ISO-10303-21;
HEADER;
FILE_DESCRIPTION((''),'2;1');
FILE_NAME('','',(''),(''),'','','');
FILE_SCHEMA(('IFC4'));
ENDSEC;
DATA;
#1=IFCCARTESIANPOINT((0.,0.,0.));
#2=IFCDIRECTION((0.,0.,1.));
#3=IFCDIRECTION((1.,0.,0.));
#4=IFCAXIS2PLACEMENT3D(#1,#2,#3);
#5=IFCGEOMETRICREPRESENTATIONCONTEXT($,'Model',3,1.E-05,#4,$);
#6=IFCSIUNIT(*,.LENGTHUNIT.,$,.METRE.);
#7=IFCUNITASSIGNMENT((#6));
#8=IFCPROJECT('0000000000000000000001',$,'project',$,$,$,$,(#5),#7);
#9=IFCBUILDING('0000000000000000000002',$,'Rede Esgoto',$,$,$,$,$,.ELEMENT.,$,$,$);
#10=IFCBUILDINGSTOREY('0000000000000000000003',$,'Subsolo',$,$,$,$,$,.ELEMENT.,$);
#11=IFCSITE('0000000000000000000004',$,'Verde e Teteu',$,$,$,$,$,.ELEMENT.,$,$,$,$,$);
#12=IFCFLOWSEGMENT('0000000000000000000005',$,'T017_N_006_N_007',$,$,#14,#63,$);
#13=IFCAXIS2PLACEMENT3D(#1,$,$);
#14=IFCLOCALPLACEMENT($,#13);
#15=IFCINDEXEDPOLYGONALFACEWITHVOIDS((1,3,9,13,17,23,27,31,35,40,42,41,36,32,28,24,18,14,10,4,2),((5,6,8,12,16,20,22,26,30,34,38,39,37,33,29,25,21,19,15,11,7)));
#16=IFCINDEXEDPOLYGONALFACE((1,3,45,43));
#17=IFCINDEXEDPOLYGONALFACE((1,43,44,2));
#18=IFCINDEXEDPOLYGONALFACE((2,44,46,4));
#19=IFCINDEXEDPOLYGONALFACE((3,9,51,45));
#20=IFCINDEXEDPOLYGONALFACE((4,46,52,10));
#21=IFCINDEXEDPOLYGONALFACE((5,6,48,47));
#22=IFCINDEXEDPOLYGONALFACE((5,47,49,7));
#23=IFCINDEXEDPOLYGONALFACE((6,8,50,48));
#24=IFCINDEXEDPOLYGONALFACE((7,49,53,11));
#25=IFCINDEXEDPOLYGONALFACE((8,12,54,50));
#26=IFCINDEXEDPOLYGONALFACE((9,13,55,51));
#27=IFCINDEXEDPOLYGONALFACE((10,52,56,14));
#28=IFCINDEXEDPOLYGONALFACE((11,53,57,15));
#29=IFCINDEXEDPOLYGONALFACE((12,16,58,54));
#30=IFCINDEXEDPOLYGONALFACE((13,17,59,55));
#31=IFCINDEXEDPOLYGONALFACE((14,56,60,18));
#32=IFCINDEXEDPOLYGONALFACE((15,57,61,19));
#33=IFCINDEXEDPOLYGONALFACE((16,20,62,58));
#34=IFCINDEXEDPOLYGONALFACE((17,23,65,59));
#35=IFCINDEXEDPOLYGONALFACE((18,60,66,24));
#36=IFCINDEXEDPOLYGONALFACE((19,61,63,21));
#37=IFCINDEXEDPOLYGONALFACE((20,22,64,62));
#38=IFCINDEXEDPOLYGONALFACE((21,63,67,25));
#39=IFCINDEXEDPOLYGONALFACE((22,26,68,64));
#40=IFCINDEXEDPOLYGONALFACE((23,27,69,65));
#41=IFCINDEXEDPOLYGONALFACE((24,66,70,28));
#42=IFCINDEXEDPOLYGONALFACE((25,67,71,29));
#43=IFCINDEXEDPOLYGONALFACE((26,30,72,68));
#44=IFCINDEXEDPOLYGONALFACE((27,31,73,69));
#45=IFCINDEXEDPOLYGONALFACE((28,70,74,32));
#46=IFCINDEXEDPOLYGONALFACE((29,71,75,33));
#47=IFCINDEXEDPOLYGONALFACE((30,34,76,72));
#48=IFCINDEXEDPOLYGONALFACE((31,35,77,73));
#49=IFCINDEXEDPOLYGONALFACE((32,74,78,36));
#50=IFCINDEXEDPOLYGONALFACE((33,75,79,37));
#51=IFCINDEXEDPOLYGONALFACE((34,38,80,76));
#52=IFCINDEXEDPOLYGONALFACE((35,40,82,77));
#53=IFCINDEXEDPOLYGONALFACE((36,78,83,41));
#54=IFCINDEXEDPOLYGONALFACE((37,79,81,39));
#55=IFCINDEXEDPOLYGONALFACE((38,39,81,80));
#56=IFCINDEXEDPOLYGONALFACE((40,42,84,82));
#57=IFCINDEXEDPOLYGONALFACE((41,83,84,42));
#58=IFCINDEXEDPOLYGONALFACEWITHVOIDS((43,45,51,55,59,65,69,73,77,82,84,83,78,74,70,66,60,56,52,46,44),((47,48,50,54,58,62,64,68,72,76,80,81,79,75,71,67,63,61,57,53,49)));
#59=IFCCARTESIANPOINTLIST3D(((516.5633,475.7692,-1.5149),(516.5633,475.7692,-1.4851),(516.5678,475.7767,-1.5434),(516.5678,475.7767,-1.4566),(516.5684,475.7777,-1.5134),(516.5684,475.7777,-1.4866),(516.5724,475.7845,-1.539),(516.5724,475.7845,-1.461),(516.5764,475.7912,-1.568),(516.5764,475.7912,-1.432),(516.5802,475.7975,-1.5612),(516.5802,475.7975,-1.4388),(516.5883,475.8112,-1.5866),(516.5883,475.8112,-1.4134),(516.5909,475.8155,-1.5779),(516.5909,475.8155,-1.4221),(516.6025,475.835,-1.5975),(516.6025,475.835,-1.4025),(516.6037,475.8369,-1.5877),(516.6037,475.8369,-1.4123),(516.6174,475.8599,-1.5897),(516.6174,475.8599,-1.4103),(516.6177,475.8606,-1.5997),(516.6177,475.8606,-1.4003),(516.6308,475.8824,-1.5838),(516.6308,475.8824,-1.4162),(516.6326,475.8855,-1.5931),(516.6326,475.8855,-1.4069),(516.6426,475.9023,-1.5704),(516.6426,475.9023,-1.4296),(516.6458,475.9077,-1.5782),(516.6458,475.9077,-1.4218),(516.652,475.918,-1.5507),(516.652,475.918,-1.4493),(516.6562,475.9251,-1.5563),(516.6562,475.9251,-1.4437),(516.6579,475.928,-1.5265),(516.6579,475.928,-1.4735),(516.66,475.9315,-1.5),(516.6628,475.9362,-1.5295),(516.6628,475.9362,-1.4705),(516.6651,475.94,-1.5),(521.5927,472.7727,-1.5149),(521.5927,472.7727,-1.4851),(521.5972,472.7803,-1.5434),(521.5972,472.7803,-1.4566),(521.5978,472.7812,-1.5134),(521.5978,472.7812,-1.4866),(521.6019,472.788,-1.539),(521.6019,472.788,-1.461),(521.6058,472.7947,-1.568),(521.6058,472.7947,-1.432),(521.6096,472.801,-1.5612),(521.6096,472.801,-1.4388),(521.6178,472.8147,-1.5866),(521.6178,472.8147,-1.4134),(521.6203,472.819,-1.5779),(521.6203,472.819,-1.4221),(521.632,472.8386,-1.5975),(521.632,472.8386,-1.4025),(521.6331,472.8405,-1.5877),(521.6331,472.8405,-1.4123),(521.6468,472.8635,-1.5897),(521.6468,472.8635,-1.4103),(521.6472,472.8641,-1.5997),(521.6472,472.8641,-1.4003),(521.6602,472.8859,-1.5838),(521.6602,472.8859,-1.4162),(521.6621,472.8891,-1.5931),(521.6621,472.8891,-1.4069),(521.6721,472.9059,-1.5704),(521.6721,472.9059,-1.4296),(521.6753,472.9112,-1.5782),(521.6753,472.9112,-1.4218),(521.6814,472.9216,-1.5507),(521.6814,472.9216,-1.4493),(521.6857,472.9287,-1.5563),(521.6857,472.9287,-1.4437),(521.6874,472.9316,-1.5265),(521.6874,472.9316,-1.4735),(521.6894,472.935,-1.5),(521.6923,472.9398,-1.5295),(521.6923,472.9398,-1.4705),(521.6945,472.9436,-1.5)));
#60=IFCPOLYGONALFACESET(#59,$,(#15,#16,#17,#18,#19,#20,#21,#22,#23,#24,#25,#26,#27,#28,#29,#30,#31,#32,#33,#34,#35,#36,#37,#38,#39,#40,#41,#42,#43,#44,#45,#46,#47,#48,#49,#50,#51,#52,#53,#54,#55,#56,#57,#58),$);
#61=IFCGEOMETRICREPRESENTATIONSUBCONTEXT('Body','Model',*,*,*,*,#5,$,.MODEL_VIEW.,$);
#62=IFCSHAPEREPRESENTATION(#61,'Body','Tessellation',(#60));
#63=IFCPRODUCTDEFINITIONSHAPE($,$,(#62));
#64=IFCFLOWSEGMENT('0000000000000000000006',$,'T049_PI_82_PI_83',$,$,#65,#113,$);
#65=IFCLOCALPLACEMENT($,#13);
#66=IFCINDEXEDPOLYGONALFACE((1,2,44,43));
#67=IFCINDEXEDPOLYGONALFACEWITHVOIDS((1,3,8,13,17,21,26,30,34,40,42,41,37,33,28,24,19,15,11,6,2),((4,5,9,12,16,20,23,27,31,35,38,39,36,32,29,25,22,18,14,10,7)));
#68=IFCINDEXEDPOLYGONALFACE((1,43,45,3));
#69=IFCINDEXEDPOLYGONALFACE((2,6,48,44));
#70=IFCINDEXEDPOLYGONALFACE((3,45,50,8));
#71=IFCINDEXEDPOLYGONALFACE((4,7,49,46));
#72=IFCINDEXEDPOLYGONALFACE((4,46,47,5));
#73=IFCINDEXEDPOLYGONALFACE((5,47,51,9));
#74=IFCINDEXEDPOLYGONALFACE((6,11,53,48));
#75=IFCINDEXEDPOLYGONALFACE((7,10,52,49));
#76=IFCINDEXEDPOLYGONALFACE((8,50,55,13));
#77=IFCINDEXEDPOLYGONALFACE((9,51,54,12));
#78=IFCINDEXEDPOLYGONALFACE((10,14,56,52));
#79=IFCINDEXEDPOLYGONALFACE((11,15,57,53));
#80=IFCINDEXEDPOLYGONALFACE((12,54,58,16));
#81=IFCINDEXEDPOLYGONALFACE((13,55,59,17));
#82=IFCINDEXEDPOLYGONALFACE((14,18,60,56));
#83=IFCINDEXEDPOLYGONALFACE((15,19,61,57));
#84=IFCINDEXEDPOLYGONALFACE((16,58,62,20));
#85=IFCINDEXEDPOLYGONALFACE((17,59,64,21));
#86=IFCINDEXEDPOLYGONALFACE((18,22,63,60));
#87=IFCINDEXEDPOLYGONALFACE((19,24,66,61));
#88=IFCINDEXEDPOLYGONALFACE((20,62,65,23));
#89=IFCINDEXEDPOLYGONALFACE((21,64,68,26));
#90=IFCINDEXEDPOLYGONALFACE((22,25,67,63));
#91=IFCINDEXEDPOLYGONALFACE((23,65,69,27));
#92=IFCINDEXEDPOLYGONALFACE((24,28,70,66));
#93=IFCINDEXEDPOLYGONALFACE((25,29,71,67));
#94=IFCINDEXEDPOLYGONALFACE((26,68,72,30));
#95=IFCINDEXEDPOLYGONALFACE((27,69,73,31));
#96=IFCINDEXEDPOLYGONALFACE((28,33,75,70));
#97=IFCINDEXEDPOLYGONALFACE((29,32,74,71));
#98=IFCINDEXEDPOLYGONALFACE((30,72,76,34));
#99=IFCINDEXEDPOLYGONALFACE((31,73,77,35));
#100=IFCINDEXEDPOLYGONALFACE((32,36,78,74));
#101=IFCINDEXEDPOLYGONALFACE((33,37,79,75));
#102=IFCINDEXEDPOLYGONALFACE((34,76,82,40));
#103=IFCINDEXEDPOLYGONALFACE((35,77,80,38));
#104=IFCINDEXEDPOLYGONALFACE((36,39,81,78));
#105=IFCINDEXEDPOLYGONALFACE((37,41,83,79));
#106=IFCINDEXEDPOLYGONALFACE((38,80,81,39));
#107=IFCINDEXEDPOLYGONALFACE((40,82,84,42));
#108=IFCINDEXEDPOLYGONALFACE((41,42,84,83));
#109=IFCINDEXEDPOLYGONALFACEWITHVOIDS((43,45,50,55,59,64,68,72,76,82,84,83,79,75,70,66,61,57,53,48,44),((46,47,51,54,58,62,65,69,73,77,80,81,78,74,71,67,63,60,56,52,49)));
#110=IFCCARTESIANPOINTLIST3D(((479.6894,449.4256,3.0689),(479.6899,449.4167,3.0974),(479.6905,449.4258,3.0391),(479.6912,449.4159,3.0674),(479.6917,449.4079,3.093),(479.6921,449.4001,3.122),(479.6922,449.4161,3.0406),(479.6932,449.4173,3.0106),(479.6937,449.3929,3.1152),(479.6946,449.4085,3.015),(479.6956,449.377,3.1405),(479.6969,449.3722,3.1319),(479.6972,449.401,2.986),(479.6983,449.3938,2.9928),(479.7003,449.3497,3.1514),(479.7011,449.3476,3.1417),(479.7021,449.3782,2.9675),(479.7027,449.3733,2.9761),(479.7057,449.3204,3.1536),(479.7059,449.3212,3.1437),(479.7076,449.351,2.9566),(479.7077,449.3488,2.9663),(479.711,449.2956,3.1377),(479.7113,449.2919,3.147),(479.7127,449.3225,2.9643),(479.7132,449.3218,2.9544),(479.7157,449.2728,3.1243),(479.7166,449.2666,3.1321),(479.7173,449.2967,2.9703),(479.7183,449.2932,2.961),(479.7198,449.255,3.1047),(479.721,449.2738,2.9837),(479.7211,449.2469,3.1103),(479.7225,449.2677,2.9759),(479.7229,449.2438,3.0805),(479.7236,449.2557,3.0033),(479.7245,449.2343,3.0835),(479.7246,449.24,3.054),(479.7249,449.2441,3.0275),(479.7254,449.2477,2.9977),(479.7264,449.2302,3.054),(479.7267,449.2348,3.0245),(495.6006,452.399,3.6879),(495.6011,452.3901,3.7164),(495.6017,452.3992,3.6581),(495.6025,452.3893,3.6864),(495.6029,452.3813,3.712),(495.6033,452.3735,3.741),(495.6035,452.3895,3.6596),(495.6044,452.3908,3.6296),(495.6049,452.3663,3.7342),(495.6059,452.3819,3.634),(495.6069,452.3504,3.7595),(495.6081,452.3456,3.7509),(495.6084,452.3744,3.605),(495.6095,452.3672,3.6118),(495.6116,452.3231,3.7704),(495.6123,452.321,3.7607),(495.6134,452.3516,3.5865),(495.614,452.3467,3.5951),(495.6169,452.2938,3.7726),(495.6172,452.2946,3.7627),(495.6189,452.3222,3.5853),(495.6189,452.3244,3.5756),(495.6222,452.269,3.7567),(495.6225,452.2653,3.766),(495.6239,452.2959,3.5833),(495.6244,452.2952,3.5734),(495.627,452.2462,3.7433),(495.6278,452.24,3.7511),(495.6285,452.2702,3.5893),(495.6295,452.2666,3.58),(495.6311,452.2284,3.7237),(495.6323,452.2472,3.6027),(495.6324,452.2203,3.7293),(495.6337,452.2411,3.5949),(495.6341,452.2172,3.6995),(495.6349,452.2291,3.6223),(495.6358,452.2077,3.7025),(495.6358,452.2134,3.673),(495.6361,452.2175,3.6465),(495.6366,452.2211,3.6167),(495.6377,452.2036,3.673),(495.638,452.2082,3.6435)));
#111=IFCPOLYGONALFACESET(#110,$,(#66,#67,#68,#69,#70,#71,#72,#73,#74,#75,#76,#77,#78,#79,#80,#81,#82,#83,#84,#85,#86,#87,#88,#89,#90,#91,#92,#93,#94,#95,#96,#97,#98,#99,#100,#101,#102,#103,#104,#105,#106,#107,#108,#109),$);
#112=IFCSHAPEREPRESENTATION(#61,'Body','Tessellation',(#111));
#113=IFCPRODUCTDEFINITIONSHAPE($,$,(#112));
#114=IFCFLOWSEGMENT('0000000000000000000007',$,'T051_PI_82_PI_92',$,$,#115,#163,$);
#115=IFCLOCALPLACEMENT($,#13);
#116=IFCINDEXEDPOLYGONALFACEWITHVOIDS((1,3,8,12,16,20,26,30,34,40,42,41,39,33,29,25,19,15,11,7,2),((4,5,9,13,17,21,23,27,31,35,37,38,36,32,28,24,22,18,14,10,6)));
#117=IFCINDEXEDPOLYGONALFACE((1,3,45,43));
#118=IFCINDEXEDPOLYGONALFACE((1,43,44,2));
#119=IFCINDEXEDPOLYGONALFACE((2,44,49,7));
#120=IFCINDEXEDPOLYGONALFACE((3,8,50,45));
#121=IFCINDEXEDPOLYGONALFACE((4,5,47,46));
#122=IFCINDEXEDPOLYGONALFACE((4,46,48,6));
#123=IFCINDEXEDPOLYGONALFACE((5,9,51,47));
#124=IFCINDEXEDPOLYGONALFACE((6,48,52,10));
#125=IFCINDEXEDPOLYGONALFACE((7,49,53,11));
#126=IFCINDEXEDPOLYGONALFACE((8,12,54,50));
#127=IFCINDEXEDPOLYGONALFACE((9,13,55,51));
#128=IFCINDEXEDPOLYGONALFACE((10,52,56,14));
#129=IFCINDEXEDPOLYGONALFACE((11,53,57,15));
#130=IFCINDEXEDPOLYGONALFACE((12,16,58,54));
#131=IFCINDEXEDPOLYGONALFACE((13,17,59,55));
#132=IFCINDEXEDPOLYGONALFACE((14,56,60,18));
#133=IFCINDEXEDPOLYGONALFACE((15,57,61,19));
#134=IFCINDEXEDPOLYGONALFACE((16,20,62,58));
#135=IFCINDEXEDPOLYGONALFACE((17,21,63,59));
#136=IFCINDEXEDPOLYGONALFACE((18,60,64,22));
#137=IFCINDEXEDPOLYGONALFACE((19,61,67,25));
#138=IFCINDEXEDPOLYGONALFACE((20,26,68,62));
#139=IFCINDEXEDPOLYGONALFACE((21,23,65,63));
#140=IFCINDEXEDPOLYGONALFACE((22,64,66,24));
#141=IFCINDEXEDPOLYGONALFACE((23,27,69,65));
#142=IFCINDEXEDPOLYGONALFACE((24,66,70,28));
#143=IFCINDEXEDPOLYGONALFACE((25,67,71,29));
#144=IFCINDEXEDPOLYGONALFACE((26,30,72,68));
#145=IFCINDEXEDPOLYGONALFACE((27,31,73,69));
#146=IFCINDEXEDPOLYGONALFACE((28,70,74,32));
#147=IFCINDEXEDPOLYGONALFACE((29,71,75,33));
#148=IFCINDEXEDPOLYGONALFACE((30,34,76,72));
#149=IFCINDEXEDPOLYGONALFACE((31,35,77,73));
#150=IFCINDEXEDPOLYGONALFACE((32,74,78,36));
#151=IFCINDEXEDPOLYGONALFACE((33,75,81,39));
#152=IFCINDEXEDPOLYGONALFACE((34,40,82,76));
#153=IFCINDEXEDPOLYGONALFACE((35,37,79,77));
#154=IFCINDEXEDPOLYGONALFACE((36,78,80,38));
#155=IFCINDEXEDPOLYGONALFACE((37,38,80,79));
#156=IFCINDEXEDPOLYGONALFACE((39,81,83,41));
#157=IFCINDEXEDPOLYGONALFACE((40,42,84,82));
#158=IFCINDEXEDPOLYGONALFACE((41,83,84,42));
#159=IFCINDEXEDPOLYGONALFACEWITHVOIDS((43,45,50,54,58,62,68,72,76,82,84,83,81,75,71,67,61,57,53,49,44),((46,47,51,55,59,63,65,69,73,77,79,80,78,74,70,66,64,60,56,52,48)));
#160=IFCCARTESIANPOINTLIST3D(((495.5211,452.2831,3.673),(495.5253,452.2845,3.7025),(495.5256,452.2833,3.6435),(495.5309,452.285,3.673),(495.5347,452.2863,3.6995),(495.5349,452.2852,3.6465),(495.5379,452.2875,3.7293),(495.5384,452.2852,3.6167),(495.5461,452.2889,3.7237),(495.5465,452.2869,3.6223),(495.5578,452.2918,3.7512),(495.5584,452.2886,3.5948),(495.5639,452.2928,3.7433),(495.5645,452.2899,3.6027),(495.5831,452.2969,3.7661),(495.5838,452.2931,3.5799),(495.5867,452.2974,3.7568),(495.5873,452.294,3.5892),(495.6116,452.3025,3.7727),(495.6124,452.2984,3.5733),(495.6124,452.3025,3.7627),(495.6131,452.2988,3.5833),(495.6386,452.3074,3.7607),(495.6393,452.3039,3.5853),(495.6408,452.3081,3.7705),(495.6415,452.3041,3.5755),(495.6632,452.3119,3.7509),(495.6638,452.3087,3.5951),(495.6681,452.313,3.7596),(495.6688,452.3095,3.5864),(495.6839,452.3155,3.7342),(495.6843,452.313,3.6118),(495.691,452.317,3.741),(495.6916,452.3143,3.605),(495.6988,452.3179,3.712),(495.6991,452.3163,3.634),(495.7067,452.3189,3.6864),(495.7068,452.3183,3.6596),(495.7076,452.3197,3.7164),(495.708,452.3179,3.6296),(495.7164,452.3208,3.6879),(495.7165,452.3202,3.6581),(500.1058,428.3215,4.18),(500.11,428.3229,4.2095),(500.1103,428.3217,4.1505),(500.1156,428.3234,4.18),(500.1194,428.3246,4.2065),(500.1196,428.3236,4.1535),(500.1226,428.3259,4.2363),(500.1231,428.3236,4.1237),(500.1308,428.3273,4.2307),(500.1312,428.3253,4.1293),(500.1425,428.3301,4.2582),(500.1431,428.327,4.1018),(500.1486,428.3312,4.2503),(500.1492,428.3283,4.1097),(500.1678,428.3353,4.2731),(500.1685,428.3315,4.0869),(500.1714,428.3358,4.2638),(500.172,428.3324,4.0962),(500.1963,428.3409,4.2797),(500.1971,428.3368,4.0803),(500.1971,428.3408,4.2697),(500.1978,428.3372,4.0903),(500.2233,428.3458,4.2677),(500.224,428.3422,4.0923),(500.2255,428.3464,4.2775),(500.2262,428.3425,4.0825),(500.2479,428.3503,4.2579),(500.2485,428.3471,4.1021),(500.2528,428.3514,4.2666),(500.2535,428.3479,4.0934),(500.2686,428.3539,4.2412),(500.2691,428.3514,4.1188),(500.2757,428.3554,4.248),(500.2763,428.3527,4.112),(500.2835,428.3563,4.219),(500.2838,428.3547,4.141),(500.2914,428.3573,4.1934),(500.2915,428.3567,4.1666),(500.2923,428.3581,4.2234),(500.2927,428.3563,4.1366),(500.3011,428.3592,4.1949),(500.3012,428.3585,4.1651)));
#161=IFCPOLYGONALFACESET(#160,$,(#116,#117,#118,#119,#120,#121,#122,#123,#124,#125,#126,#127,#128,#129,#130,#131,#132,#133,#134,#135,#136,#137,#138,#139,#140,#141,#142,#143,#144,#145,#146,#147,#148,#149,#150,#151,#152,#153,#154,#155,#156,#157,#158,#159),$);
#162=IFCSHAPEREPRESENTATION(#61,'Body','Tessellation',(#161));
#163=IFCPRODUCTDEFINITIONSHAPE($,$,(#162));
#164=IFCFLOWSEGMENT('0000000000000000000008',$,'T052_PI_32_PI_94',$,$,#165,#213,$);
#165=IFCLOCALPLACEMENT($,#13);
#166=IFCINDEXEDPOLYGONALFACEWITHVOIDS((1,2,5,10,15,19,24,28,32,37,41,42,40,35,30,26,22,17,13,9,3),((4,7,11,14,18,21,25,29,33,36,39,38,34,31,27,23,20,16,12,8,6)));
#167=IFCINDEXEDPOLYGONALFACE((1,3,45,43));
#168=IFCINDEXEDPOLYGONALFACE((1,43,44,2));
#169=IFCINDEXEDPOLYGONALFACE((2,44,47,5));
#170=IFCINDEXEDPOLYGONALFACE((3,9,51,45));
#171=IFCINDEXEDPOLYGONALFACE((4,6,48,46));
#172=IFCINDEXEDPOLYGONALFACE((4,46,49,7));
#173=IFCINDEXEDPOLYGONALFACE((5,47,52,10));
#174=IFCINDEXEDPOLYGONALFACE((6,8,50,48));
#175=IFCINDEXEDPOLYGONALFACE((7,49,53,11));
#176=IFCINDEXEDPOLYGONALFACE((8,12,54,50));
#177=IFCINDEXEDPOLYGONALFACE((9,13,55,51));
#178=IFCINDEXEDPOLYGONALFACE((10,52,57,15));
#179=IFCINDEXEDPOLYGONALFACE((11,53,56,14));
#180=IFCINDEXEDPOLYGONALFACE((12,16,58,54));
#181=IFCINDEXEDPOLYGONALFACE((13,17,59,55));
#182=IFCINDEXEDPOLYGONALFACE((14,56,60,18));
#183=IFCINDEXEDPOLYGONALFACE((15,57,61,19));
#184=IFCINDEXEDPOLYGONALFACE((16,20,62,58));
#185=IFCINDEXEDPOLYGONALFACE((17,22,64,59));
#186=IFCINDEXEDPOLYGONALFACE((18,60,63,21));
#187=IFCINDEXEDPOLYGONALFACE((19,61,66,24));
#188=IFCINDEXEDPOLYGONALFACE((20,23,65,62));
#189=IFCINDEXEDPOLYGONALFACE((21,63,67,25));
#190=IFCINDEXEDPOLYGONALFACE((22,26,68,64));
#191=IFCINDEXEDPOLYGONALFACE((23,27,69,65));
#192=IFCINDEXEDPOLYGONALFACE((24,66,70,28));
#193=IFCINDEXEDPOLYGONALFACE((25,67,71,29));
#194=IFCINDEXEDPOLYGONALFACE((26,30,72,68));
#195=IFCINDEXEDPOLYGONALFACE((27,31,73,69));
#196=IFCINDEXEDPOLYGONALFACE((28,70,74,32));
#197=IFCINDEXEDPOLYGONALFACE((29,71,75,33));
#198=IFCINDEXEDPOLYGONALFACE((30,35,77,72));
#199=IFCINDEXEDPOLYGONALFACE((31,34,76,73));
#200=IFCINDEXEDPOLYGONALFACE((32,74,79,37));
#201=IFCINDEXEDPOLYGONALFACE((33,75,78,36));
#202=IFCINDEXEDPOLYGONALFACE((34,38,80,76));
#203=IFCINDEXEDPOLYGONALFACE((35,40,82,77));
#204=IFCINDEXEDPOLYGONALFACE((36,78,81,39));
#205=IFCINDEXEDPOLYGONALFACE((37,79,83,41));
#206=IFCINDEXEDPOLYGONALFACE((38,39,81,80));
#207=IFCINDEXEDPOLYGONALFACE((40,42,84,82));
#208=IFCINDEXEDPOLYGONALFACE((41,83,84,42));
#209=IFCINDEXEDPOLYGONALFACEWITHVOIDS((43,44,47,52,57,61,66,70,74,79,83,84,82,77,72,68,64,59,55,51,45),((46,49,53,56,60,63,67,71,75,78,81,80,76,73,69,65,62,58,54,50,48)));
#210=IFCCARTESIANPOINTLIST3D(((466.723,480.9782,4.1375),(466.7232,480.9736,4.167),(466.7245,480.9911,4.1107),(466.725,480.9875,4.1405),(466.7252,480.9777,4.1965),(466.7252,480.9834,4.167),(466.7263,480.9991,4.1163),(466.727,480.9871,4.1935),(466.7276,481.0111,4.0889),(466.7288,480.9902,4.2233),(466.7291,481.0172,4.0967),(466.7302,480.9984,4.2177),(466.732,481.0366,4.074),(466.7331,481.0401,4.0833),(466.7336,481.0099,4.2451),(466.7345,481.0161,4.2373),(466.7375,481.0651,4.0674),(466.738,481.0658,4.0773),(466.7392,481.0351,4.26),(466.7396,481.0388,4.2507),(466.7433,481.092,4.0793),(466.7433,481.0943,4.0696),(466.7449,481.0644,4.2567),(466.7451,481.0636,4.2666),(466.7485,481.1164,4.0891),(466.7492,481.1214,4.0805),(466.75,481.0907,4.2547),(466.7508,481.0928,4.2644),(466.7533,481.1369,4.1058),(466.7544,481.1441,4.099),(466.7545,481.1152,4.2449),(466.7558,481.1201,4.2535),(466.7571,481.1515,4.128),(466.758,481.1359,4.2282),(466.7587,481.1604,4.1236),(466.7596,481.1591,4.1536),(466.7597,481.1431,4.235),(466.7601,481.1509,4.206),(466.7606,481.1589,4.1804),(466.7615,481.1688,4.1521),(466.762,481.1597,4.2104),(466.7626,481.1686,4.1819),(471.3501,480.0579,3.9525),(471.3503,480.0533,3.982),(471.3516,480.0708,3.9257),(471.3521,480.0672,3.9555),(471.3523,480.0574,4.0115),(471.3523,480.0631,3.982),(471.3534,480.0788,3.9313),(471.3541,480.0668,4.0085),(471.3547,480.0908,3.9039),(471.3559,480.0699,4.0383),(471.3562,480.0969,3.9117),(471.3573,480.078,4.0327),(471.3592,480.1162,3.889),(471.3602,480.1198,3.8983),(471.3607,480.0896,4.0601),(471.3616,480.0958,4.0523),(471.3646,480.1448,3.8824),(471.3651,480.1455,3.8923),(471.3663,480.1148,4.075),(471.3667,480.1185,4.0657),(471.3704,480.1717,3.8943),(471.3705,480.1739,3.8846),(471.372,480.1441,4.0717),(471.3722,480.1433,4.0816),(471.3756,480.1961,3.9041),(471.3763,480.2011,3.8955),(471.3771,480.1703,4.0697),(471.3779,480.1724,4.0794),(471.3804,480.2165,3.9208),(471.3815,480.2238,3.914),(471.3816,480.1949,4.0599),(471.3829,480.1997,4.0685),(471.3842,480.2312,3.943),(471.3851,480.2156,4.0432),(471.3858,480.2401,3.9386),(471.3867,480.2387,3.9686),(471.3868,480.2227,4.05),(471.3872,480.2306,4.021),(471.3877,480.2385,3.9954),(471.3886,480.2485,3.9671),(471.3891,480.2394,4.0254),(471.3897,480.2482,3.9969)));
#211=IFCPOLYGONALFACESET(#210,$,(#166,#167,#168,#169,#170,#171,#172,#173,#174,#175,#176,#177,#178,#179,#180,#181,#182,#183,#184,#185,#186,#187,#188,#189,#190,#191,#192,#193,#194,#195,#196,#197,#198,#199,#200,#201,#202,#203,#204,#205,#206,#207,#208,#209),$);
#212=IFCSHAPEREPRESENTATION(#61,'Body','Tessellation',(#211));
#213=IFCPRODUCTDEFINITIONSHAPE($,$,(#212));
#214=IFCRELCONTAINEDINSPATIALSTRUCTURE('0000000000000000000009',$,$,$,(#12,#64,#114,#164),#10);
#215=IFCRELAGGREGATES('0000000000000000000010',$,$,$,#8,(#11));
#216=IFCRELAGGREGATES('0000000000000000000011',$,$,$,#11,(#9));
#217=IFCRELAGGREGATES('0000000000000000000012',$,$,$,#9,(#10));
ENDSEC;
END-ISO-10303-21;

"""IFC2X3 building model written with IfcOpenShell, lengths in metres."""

from ifc_helpers import new_model, entity, si_unit, frame, origin_with_axes, place, context, subcontext, project, spatial, element, save


model = new_model("IFC2X3")

# Units and contexts
model_context = context("Model", 3, precision=1e-05, world=origin_with_axes())
body_context = subcontext(model_context, "Body", "Model", "MODEL_VIEW")
ifc_project = project(units=[si_unit("LENGTHUNIT", "METRE")], contexts=[model_context])

# Site, building, storey
site = spatial("IfcSite", under=ifc_project, Name="Verde e Teteu", CompositionType="ELEMENT")
building = spatial("IfcBuilding", under=site, Name="Rede Esgoto", CompositionType="ELEMENT")
storey = spatial("IfcBuildingStorey", under=building, Name="Subsolo", CompositionType="ELEMENT")

# Flow segments
flow_segment_1_placement = place(None, frame((516.6139, 475.8541, -1.5), z_axis=(0.0, 0.0, 1.0), x_axis=(1.0, 0.0, 0.0)))
element("IfcFlowSegment", 1, at=flow_segment_1_placement, inside=storey, Name="T017_N_006_N_007", context=body_context, shape_type="SweptSolid", body=[
    entity("IfcSweptDiskSolid", entity("IfcPolyline", [entity("IfcCartesianPoint", [0.0, 0.0, 0.0]), entity("IfcCartesianPoint", [5.0294, -2.9964, 0.0])]), 0.1, 0.09),
])
flow_segment_2_placement = place(None, frame((495.6193, 452.3019, 3.673), z_axis=(0.0, 0.0, 1.0), x_axis=(1.0, 0.0, 0.0)))
element("IfcFlowSegment", 2, at=flow_segment_2_placement, inside=storey, Name="T049_PI_82_PI_83", context=body_context, shape_type="SweptSolid", body=[
    entity("IfcSweptDiskSolid", entity("IfcPolyline", [entity("IfcCartesianPoint", [0.0, 0.0, 0.0]), entity("IfcCartesianPoint", [-15.9112, -2.9734, -0.619])]), 0.1, 0.09),
])
flow_segment_3_placement = place(None, frame((495.6193, 452.3019, 3.673), z_axis=(0.0, 0.0, 1.0), x_axis=(1.0, 0.0, 0.0)))
element("IfcFlowSegment", 3, at=flow_segment_3_placement, inside=storey, Name="T051_PI_82_PI_92", context=body_context, shape_type="SweptSolid", body=[
    entity("IfcSweptDiskSolid", entity("IfcPolyline", [entity("IfcCartesianPoint", [0.0, 0.0, 0.0]), entity("IfcCartesianPoint", [4.5847, -23.9616, 0.507])]), 0.1, 0.09),
])
flow_segment_4_placement = place(None, frame((471.3699, 480.1514, 3.982), z_axis=(0.0, 0.0, 1.0), x_axis=(1.0, 0.0, 0.0)))
element("IfcFlowSegment", 4, at=flow_segment_4_placement, inside=storey, Name="T052_PI_32_PI_94", context=body_context, shape_type="SweptSolid", body=[
    entity("IfcSweptDiskSolid", entity("IfcPolyline", [entity("IfcCartesianPoint", [0.0, 0.0, 0.0]), entity("IfcCartesianPoint", [-4.6271, 0.9203, 0.185])]), 0.1, 0.09),
])

save(model, "model.ifc")
